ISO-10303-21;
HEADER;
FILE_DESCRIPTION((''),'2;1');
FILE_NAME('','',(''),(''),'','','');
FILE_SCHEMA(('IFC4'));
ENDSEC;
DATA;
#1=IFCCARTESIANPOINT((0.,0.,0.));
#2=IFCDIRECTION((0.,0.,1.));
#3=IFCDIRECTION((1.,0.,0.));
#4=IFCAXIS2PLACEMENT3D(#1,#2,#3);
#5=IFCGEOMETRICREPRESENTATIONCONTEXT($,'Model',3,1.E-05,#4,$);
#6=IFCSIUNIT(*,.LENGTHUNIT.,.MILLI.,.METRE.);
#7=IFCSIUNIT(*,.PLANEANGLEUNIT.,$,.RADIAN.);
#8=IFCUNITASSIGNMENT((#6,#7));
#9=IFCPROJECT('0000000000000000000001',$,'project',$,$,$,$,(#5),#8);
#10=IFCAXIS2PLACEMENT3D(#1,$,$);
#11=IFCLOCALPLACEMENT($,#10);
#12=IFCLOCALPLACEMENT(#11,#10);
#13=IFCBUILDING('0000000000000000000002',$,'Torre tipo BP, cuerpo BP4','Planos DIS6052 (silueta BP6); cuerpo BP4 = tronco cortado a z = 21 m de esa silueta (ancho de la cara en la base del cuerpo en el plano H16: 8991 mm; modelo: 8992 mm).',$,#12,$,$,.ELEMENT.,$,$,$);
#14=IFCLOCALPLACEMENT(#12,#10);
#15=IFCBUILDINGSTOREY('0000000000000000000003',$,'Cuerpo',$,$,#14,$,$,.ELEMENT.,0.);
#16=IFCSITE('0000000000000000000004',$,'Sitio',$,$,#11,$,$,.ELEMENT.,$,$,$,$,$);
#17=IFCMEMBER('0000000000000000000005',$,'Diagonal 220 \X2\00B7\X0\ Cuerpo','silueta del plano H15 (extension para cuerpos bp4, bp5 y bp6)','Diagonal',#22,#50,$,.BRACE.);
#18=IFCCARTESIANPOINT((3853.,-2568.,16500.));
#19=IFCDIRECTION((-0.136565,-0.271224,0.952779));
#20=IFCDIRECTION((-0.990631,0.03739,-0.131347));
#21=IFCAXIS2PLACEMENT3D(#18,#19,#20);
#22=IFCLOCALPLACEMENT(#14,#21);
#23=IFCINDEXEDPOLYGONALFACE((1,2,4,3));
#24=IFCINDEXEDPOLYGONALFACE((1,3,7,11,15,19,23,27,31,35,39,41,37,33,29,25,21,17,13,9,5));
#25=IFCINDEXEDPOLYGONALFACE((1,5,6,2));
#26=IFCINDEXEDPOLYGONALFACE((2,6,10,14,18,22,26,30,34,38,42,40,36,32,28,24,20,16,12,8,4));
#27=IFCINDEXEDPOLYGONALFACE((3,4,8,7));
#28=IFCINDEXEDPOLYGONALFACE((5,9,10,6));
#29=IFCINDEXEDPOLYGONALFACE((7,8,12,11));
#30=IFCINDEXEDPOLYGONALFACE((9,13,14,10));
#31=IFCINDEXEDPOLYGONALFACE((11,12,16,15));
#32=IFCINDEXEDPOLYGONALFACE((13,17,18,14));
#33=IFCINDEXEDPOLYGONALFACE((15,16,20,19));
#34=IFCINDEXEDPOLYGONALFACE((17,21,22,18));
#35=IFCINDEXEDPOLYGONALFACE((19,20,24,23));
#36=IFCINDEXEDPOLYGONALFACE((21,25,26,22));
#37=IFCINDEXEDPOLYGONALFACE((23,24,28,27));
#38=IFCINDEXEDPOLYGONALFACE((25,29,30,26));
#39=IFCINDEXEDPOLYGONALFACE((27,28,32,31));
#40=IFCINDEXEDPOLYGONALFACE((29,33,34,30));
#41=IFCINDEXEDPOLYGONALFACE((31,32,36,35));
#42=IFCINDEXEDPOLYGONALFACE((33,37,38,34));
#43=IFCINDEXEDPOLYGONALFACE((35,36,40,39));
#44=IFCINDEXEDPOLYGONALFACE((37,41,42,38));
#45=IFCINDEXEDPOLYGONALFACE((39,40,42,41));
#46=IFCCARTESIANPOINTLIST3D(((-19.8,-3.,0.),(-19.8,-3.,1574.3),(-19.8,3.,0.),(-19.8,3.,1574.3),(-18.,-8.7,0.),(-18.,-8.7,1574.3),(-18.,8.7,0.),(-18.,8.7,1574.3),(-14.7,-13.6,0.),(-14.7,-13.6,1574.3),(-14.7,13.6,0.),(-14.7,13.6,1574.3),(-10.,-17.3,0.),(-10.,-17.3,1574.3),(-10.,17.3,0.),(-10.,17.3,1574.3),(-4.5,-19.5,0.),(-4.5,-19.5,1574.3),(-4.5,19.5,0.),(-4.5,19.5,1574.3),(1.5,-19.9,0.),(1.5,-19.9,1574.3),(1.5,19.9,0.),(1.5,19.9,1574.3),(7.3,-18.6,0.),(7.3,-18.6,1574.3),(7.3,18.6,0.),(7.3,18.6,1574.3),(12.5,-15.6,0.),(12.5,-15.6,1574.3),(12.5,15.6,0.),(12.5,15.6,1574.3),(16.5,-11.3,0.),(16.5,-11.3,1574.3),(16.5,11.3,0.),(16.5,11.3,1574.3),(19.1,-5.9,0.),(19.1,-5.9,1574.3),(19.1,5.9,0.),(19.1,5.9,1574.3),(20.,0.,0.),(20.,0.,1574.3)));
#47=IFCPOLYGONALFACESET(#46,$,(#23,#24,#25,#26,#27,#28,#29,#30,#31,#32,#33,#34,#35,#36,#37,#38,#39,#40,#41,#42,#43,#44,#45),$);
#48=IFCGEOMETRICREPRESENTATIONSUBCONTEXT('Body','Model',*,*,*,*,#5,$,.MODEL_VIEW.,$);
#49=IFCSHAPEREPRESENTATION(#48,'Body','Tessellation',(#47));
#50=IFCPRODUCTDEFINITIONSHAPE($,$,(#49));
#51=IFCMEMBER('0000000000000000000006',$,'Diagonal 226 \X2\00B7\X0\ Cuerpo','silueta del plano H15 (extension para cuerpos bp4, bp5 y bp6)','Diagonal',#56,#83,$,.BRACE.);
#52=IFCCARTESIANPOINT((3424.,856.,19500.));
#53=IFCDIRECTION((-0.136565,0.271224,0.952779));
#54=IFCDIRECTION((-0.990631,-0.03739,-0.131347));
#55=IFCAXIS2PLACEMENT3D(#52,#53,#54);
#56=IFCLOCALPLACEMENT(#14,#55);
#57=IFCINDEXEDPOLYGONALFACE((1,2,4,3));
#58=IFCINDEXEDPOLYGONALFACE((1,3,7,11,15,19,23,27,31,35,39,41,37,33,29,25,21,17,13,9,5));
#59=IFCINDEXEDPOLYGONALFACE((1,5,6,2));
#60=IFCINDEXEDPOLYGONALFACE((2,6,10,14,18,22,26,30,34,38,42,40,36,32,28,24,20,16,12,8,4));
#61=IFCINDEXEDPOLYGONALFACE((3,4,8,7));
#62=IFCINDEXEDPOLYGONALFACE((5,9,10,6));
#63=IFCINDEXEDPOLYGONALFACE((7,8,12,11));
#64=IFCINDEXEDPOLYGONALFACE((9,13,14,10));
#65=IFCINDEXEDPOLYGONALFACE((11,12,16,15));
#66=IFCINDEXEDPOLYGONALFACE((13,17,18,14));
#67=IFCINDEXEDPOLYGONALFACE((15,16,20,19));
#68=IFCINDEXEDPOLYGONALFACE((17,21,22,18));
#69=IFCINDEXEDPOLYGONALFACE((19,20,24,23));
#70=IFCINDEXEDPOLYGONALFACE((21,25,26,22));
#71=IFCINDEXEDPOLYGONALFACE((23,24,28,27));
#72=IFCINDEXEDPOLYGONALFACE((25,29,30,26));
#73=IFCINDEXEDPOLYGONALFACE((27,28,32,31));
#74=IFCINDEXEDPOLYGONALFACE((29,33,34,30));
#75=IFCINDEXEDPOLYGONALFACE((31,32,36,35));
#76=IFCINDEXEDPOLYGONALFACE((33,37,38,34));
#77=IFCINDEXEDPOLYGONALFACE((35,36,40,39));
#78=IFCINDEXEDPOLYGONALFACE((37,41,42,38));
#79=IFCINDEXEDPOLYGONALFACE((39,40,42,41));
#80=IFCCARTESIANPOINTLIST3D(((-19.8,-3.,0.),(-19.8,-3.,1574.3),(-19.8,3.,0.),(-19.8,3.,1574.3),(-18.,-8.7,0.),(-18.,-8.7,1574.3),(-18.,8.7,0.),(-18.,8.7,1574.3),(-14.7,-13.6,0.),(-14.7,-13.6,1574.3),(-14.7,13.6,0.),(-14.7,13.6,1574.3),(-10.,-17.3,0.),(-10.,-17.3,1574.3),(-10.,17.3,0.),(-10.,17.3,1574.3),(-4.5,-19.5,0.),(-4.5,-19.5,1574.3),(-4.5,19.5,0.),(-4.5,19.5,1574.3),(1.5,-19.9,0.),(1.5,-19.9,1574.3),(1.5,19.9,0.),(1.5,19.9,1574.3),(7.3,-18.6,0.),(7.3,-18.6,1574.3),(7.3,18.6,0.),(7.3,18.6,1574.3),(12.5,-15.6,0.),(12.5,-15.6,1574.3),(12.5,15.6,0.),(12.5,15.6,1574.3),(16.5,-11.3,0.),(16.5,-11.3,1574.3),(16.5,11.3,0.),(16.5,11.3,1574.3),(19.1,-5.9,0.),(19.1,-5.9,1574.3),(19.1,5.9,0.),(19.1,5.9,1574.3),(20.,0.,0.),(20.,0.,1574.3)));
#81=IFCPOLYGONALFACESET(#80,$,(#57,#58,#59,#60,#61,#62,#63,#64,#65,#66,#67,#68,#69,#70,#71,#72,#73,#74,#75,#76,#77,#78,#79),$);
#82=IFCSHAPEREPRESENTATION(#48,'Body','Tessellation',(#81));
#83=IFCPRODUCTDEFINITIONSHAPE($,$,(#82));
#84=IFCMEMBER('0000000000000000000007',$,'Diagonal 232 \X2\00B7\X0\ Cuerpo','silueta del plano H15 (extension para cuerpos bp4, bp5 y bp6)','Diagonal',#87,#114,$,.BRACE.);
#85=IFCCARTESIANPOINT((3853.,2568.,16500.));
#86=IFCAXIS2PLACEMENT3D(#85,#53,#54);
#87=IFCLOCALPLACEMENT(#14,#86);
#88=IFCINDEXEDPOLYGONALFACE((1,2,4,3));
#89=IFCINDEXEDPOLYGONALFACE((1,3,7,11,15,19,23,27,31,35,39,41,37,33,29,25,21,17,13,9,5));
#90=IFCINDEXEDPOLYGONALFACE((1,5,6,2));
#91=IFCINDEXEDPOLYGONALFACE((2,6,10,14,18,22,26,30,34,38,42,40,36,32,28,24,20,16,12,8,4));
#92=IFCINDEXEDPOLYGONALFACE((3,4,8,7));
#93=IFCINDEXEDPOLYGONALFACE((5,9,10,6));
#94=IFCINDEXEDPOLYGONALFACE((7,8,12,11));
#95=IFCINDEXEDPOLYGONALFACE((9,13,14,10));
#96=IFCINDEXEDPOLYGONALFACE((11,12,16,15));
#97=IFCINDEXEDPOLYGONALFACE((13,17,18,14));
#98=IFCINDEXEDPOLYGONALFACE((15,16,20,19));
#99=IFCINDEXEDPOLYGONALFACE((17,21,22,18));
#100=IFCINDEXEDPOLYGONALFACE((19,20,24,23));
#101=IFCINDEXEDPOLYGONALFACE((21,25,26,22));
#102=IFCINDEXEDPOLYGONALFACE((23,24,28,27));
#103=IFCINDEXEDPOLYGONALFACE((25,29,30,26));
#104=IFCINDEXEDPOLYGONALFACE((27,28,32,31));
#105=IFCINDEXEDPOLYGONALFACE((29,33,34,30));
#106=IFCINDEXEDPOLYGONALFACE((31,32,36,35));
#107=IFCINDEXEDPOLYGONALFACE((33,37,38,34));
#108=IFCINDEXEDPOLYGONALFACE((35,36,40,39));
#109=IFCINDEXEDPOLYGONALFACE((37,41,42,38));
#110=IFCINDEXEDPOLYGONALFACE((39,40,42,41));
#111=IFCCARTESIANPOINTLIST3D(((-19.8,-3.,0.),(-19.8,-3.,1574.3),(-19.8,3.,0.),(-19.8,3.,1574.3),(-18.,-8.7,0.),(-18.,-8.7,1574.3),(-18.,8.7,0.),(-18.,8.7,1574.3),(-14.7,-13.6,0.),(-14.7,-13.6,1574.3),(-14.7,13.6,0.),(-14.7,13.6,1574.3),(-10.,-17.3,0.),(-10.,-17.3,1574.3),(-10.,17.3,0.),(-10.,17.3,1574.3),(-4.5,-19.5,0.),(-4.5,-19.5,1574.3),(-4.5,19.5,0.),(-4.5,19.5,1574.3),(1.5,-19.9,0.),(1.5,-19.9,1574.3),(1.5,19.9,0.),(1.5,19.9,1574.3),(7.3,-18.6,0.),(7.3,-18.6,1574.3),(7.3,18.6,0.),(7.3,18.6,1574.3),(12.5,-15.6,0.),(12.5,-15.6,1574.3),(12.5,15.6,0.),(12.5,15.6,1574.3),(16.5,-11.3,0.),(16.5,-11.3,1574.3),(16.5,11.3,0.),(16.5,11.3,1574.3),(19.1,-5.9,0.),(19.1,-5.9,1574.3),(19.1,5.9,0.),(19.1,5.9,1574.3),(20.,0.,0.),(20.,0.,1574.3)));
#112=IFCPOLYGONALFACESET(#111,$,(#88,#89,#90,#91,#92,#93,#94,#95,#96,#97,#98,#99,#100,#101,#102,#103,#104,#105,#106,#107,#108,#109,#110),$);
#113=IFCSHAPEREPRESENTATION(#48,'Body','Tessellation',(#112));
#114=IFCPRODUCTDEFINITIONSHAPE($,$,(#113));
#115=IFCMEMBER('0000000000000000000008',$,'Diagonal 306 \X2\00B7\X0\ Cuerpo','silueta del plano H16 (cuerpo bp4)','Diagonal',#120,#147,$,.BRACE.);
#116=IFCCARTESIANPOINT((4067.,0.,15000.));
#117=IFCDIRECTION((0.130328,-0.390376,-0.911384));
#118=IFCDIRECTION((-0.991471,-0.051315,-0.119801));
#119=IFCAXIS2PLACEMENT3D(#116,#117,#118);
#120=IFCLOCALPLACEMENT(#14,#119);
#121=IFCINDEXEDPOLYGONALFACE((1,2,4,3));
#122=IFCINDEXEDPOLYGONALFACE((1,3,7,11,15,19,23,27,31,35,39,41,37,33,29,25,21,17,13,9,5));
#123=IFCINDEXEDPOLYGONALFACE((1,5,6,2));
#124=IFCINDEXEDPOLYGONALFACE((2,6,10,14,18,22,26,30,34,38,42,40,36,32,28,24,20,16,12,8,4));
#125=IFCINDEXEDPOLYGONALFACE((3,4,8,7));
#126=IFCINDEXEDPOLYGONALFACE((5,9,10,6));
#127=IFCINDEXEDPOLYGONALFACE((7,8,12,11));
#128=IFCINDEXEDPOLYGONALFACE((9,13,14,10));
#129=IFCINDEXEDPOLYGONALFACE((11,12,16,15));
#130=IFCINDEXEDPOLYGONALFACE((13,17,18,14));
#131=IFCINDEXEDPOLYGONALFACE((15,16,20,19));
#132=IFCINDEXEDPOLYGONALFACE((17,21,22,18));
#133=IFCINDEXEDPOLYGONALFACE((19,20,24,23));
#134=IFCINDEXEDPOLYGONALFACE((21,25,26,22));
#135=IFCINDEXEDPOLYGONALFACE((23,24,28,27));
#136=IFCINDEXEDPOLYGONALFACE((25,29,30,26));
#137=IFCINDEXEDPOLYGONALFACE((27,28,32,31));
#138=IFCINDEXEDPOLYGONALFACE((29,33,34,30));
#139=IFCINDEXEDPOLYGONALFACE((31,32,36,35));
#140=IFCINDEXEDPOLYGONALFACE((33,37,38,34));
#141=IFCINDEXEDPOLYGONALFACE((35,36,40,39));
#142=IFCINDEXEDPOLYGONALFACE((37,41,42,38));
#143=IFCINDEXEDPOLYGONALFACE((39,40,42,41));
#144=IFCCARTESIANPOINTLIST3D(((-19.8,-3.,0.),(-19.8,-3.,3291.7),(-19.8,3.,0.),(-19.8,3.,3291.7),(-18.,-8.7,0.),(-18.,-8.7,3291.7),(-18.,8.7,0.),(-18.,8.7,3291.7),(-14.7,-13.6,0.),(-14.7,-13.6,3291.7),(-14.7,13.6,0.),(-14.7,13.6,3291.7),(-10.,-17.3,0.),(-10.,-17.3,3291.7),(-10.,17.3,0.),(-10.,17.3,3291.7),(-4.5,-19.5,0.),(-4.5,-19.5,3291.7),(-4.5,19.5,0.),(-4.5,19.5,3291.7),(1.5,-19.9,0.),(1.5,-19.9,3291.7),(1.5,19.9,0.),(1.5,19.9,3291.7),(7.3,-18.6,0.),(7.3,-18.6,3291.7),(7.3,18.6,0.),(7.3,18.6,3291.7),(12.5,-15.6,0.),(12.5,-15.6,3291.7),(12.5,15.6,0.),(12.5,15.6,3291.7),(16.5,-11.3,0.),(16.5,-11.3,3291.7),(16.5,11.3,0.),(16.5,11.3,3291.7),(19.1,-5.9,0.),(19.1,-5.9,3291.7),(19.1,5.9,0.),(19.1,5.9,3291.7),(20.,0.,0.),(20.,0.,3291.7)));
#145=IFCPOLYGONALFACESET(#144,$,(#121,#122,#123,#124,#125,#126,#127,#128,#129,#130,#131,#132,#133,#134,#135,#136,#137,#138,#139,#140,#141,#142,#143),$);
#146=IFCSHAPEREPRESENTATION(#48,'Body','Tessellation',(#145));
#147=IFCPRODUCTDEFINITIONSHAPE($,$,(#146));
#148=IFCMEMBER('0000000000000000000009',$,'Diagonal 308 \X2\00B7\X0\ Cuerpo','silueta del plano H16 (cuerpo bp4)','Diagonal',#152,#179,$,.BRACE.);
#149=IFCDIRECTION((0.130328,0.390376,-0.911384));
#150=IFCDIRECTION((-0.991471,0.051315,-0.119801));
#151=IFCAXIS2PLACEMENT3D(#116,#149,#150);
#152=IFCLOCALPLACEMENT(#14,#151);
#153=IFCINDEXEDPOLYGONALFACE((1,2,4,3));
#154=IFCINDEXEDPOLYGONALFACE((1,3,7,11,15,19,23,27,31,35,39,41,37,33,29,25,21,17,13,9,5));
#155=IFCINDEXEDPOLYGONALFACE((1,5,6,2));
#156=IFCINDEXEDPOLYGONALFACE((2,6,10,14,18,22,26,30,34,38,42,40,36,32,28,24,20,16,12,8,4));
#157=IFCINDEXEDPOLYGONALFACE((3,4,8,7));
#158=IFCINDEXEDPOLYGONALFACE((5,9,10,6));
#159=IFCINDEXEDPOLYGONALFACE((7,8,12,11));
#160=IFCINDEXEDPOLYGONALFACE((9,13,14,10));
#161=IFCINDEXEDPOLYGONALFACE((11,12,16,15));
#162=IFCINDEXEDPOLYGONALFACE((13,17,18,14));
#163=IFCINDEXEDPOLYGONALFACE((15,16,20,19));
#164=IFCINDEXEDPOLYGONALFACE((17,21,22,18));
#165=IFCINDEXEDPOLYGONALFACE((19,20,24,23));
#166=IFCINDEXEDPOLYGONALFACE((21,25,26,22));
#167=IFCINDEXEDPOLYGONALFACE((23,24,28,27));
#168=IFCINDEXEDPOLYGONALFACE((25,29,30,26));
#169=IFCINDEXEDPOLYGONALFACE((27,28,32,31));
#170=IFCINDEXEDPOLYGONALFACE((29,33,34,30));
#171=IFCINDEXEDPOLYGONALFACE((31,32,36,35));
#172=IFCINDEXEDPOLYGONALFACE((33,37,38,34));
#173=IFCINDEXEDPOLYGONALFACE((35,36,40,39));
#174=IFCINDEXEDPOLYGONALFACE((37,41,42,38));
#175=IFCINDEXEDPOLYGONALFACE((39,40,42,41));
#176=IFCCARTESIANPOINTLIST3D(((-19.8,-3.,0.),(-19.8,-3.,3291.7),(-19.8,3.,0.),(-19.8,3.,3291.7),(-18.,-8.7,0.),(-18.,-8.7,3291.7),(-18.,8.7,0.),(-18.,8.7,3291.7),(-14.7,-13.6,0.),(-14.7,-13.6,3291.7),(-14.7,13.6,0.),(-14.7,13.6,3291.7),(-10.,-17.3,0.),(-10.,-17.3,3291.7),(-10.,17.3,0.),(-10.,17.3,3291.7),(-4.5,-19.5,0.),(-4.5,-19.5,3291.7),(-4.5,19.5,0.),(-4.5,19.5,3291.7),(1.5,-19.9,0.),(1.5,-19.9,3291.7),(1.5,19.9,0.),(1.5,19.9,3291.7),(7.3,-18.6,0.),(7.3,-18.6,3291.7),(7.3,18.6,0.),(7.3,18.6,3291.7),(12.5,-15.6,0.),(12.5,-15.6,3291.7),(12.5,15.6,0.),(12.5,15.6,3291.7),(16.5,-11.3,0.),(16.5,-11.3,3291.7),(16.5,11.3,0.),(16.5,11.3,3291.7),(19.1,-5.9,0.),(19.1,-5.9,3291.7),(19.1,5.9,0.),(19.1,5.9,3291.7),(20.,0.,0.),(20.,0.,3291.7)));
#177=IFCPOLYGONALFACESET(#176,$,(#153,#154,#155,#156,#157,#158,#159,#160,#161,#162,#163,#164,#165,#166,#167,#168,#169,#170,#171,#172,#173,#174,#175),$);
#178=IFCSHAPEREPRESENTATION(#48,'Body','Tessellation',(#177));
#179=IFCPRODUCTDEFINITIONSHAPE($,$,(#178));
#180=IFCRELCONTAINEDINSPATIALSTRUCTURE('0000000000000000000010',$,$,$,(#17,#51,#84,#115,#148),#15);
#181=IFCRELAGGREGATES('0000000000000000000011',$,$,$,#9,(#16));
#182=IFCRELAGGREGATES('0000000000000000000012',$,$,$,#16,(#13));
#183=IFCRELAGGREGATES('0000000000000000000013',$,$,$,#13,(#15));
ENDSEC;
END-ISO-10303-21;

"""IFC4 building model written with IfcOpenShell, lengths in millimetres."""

from ifc_helpers import new_model, si_unit, frame, origin, origin_with_axes, place, context, subcontext, project, spatial, circle, extrude, element, save


model = new_model("IFC4")

# Units and contexts
model_context = context("Model", 3, precision=1e-05, world=origin_with_axes())
body_context = subcontext(model_context, "Body", "Model", "MODEL_VIEW")
ifc_project = project(units=[si_unit("LENGTHUNIT", "METRE", prefix="MILLI"), si_unit("PLANEANGLEUNIT", "RADIAN")], contexts=[model_context])

# Site, building, storey
site_placement = place(None, origin())
site = spatial("IfcSite", under=ifc_project, at=site_placement, Name="Sitio", CompositionType="ELEMENT")
building_placement = place(site_placement, origin())
building = spatial("IfcBuilding", under=site, at=building_placement, Name="Torre tipo BP, cuerpo BP4", Description="Planos DIS6052 (silueta BP6); cuerpo BP4 = tronco cortado a z = 21 m de esa silueta (ancho de la cara en la base del cuerpo en el plano H16: 8991 mm; modelo: 8992 mm).", CompositionType="ELEMENT")
storey_placement = place(building_placement, origin())
storey = spatial("IfcBuildingStorey", under=building, at=storey_placement, Name="Cuerpo", CompositionType="ELEMENT", Elevation=0.0)

# Members
member_1_placement = place(storey_placement, frame((3853.0, -2568.0, 16500.0), z_axis=(-0.136565, -0.271224, 0.952779), x_axis=(-0.990631, 0.03739, -0.131347)))
element("IfcMember", 1, at=member_1_placement, inside=storey, Name="Diagonal 220 · Cuerpo", Description="silueta del plano H15 (extension para cuerpos bp4, bp5 y bp6)", ObjectType="Diagonal", PredefinedType="BRACE", context=body_context, shape_type="SweptSolid", body=[
    extrude(circle(Radius=20.0), None, (0.0, 0.0, 1.0), 1574.3),
])
member_2_placement = place(storey_placement, frame((3424.0, 856.0, 19500.0), z_axis=(-0.136565, 0.271224, 0.952779), x_axis=(-0.990631, -0.03739, -0.131347)))
element("IfcMember", 2, at=member_2_placement, inside=storey, Name="Diagonal 226 · Cuerpo", Description="silueta del plano H15 (extension para cuerpos bp4, bp5 y bp6)", ObjectType="Diagonal", PredefinedType="BRACE", context=body_context, shape_type="SweptSolid", body=[
    extrude(circle(Radius=20.0), None, (0.0, 0.0, 1.0), 1574.3),
])
member_3_placement = place(storey_placement, frame((3853.0, 2568.0, 16500.0), z_axis=(-0.136565, 0.271224, 0.952779), x_axis=(-0.990631, -0.03739, -0.131347)))
element("IfcMember", 3, at=member_3_placement, inside=storey, Name="Diagonal 232 · Cuerpo", Description="silueta del plano H15 (extension para cuerpos bp4, bp5 y bp6)", ObjectType="Diagonal", PredefinedType="BRACE", context=body_context, shape_type="SweptSolid", body=[
    extrude(circle(Radius=20.0), None, (0.0, 0.0, 1.0), 1574.3),
])
for number, where, z_axis, x_axis, name in (
    (4, (4067.0, 0.0, 15000.0), (0.130328, -0.390376, -0.911384), (-0.991471, -0.051315, -0.119801), "Diagonal 306 · Cuerpo"),
    (5, (4067.0, 0.0, 15000.0), (0.130328, 0.390376, -0.911384), (-0.991471, 0.051315, -0.119801), "Diagonal 308 · Cuerpo"),
):
    element("IfcMember", number, at=place(storey_placement, frame(where, z_axis=z_axis, x_axis=x_axis)), inside=storey, Name=name, Description="silueta del plano H16 (cuerpo bp4)", ObjectType="Diagonal", PredefinedType="BRACE", context=body_context, shape_type="SweptSolid", body=[
        extrude(circle(Radius=20.0), None, (0.0, 0.0, 1.0), 3291.7),
    ])

save(model, "model.ifc")
